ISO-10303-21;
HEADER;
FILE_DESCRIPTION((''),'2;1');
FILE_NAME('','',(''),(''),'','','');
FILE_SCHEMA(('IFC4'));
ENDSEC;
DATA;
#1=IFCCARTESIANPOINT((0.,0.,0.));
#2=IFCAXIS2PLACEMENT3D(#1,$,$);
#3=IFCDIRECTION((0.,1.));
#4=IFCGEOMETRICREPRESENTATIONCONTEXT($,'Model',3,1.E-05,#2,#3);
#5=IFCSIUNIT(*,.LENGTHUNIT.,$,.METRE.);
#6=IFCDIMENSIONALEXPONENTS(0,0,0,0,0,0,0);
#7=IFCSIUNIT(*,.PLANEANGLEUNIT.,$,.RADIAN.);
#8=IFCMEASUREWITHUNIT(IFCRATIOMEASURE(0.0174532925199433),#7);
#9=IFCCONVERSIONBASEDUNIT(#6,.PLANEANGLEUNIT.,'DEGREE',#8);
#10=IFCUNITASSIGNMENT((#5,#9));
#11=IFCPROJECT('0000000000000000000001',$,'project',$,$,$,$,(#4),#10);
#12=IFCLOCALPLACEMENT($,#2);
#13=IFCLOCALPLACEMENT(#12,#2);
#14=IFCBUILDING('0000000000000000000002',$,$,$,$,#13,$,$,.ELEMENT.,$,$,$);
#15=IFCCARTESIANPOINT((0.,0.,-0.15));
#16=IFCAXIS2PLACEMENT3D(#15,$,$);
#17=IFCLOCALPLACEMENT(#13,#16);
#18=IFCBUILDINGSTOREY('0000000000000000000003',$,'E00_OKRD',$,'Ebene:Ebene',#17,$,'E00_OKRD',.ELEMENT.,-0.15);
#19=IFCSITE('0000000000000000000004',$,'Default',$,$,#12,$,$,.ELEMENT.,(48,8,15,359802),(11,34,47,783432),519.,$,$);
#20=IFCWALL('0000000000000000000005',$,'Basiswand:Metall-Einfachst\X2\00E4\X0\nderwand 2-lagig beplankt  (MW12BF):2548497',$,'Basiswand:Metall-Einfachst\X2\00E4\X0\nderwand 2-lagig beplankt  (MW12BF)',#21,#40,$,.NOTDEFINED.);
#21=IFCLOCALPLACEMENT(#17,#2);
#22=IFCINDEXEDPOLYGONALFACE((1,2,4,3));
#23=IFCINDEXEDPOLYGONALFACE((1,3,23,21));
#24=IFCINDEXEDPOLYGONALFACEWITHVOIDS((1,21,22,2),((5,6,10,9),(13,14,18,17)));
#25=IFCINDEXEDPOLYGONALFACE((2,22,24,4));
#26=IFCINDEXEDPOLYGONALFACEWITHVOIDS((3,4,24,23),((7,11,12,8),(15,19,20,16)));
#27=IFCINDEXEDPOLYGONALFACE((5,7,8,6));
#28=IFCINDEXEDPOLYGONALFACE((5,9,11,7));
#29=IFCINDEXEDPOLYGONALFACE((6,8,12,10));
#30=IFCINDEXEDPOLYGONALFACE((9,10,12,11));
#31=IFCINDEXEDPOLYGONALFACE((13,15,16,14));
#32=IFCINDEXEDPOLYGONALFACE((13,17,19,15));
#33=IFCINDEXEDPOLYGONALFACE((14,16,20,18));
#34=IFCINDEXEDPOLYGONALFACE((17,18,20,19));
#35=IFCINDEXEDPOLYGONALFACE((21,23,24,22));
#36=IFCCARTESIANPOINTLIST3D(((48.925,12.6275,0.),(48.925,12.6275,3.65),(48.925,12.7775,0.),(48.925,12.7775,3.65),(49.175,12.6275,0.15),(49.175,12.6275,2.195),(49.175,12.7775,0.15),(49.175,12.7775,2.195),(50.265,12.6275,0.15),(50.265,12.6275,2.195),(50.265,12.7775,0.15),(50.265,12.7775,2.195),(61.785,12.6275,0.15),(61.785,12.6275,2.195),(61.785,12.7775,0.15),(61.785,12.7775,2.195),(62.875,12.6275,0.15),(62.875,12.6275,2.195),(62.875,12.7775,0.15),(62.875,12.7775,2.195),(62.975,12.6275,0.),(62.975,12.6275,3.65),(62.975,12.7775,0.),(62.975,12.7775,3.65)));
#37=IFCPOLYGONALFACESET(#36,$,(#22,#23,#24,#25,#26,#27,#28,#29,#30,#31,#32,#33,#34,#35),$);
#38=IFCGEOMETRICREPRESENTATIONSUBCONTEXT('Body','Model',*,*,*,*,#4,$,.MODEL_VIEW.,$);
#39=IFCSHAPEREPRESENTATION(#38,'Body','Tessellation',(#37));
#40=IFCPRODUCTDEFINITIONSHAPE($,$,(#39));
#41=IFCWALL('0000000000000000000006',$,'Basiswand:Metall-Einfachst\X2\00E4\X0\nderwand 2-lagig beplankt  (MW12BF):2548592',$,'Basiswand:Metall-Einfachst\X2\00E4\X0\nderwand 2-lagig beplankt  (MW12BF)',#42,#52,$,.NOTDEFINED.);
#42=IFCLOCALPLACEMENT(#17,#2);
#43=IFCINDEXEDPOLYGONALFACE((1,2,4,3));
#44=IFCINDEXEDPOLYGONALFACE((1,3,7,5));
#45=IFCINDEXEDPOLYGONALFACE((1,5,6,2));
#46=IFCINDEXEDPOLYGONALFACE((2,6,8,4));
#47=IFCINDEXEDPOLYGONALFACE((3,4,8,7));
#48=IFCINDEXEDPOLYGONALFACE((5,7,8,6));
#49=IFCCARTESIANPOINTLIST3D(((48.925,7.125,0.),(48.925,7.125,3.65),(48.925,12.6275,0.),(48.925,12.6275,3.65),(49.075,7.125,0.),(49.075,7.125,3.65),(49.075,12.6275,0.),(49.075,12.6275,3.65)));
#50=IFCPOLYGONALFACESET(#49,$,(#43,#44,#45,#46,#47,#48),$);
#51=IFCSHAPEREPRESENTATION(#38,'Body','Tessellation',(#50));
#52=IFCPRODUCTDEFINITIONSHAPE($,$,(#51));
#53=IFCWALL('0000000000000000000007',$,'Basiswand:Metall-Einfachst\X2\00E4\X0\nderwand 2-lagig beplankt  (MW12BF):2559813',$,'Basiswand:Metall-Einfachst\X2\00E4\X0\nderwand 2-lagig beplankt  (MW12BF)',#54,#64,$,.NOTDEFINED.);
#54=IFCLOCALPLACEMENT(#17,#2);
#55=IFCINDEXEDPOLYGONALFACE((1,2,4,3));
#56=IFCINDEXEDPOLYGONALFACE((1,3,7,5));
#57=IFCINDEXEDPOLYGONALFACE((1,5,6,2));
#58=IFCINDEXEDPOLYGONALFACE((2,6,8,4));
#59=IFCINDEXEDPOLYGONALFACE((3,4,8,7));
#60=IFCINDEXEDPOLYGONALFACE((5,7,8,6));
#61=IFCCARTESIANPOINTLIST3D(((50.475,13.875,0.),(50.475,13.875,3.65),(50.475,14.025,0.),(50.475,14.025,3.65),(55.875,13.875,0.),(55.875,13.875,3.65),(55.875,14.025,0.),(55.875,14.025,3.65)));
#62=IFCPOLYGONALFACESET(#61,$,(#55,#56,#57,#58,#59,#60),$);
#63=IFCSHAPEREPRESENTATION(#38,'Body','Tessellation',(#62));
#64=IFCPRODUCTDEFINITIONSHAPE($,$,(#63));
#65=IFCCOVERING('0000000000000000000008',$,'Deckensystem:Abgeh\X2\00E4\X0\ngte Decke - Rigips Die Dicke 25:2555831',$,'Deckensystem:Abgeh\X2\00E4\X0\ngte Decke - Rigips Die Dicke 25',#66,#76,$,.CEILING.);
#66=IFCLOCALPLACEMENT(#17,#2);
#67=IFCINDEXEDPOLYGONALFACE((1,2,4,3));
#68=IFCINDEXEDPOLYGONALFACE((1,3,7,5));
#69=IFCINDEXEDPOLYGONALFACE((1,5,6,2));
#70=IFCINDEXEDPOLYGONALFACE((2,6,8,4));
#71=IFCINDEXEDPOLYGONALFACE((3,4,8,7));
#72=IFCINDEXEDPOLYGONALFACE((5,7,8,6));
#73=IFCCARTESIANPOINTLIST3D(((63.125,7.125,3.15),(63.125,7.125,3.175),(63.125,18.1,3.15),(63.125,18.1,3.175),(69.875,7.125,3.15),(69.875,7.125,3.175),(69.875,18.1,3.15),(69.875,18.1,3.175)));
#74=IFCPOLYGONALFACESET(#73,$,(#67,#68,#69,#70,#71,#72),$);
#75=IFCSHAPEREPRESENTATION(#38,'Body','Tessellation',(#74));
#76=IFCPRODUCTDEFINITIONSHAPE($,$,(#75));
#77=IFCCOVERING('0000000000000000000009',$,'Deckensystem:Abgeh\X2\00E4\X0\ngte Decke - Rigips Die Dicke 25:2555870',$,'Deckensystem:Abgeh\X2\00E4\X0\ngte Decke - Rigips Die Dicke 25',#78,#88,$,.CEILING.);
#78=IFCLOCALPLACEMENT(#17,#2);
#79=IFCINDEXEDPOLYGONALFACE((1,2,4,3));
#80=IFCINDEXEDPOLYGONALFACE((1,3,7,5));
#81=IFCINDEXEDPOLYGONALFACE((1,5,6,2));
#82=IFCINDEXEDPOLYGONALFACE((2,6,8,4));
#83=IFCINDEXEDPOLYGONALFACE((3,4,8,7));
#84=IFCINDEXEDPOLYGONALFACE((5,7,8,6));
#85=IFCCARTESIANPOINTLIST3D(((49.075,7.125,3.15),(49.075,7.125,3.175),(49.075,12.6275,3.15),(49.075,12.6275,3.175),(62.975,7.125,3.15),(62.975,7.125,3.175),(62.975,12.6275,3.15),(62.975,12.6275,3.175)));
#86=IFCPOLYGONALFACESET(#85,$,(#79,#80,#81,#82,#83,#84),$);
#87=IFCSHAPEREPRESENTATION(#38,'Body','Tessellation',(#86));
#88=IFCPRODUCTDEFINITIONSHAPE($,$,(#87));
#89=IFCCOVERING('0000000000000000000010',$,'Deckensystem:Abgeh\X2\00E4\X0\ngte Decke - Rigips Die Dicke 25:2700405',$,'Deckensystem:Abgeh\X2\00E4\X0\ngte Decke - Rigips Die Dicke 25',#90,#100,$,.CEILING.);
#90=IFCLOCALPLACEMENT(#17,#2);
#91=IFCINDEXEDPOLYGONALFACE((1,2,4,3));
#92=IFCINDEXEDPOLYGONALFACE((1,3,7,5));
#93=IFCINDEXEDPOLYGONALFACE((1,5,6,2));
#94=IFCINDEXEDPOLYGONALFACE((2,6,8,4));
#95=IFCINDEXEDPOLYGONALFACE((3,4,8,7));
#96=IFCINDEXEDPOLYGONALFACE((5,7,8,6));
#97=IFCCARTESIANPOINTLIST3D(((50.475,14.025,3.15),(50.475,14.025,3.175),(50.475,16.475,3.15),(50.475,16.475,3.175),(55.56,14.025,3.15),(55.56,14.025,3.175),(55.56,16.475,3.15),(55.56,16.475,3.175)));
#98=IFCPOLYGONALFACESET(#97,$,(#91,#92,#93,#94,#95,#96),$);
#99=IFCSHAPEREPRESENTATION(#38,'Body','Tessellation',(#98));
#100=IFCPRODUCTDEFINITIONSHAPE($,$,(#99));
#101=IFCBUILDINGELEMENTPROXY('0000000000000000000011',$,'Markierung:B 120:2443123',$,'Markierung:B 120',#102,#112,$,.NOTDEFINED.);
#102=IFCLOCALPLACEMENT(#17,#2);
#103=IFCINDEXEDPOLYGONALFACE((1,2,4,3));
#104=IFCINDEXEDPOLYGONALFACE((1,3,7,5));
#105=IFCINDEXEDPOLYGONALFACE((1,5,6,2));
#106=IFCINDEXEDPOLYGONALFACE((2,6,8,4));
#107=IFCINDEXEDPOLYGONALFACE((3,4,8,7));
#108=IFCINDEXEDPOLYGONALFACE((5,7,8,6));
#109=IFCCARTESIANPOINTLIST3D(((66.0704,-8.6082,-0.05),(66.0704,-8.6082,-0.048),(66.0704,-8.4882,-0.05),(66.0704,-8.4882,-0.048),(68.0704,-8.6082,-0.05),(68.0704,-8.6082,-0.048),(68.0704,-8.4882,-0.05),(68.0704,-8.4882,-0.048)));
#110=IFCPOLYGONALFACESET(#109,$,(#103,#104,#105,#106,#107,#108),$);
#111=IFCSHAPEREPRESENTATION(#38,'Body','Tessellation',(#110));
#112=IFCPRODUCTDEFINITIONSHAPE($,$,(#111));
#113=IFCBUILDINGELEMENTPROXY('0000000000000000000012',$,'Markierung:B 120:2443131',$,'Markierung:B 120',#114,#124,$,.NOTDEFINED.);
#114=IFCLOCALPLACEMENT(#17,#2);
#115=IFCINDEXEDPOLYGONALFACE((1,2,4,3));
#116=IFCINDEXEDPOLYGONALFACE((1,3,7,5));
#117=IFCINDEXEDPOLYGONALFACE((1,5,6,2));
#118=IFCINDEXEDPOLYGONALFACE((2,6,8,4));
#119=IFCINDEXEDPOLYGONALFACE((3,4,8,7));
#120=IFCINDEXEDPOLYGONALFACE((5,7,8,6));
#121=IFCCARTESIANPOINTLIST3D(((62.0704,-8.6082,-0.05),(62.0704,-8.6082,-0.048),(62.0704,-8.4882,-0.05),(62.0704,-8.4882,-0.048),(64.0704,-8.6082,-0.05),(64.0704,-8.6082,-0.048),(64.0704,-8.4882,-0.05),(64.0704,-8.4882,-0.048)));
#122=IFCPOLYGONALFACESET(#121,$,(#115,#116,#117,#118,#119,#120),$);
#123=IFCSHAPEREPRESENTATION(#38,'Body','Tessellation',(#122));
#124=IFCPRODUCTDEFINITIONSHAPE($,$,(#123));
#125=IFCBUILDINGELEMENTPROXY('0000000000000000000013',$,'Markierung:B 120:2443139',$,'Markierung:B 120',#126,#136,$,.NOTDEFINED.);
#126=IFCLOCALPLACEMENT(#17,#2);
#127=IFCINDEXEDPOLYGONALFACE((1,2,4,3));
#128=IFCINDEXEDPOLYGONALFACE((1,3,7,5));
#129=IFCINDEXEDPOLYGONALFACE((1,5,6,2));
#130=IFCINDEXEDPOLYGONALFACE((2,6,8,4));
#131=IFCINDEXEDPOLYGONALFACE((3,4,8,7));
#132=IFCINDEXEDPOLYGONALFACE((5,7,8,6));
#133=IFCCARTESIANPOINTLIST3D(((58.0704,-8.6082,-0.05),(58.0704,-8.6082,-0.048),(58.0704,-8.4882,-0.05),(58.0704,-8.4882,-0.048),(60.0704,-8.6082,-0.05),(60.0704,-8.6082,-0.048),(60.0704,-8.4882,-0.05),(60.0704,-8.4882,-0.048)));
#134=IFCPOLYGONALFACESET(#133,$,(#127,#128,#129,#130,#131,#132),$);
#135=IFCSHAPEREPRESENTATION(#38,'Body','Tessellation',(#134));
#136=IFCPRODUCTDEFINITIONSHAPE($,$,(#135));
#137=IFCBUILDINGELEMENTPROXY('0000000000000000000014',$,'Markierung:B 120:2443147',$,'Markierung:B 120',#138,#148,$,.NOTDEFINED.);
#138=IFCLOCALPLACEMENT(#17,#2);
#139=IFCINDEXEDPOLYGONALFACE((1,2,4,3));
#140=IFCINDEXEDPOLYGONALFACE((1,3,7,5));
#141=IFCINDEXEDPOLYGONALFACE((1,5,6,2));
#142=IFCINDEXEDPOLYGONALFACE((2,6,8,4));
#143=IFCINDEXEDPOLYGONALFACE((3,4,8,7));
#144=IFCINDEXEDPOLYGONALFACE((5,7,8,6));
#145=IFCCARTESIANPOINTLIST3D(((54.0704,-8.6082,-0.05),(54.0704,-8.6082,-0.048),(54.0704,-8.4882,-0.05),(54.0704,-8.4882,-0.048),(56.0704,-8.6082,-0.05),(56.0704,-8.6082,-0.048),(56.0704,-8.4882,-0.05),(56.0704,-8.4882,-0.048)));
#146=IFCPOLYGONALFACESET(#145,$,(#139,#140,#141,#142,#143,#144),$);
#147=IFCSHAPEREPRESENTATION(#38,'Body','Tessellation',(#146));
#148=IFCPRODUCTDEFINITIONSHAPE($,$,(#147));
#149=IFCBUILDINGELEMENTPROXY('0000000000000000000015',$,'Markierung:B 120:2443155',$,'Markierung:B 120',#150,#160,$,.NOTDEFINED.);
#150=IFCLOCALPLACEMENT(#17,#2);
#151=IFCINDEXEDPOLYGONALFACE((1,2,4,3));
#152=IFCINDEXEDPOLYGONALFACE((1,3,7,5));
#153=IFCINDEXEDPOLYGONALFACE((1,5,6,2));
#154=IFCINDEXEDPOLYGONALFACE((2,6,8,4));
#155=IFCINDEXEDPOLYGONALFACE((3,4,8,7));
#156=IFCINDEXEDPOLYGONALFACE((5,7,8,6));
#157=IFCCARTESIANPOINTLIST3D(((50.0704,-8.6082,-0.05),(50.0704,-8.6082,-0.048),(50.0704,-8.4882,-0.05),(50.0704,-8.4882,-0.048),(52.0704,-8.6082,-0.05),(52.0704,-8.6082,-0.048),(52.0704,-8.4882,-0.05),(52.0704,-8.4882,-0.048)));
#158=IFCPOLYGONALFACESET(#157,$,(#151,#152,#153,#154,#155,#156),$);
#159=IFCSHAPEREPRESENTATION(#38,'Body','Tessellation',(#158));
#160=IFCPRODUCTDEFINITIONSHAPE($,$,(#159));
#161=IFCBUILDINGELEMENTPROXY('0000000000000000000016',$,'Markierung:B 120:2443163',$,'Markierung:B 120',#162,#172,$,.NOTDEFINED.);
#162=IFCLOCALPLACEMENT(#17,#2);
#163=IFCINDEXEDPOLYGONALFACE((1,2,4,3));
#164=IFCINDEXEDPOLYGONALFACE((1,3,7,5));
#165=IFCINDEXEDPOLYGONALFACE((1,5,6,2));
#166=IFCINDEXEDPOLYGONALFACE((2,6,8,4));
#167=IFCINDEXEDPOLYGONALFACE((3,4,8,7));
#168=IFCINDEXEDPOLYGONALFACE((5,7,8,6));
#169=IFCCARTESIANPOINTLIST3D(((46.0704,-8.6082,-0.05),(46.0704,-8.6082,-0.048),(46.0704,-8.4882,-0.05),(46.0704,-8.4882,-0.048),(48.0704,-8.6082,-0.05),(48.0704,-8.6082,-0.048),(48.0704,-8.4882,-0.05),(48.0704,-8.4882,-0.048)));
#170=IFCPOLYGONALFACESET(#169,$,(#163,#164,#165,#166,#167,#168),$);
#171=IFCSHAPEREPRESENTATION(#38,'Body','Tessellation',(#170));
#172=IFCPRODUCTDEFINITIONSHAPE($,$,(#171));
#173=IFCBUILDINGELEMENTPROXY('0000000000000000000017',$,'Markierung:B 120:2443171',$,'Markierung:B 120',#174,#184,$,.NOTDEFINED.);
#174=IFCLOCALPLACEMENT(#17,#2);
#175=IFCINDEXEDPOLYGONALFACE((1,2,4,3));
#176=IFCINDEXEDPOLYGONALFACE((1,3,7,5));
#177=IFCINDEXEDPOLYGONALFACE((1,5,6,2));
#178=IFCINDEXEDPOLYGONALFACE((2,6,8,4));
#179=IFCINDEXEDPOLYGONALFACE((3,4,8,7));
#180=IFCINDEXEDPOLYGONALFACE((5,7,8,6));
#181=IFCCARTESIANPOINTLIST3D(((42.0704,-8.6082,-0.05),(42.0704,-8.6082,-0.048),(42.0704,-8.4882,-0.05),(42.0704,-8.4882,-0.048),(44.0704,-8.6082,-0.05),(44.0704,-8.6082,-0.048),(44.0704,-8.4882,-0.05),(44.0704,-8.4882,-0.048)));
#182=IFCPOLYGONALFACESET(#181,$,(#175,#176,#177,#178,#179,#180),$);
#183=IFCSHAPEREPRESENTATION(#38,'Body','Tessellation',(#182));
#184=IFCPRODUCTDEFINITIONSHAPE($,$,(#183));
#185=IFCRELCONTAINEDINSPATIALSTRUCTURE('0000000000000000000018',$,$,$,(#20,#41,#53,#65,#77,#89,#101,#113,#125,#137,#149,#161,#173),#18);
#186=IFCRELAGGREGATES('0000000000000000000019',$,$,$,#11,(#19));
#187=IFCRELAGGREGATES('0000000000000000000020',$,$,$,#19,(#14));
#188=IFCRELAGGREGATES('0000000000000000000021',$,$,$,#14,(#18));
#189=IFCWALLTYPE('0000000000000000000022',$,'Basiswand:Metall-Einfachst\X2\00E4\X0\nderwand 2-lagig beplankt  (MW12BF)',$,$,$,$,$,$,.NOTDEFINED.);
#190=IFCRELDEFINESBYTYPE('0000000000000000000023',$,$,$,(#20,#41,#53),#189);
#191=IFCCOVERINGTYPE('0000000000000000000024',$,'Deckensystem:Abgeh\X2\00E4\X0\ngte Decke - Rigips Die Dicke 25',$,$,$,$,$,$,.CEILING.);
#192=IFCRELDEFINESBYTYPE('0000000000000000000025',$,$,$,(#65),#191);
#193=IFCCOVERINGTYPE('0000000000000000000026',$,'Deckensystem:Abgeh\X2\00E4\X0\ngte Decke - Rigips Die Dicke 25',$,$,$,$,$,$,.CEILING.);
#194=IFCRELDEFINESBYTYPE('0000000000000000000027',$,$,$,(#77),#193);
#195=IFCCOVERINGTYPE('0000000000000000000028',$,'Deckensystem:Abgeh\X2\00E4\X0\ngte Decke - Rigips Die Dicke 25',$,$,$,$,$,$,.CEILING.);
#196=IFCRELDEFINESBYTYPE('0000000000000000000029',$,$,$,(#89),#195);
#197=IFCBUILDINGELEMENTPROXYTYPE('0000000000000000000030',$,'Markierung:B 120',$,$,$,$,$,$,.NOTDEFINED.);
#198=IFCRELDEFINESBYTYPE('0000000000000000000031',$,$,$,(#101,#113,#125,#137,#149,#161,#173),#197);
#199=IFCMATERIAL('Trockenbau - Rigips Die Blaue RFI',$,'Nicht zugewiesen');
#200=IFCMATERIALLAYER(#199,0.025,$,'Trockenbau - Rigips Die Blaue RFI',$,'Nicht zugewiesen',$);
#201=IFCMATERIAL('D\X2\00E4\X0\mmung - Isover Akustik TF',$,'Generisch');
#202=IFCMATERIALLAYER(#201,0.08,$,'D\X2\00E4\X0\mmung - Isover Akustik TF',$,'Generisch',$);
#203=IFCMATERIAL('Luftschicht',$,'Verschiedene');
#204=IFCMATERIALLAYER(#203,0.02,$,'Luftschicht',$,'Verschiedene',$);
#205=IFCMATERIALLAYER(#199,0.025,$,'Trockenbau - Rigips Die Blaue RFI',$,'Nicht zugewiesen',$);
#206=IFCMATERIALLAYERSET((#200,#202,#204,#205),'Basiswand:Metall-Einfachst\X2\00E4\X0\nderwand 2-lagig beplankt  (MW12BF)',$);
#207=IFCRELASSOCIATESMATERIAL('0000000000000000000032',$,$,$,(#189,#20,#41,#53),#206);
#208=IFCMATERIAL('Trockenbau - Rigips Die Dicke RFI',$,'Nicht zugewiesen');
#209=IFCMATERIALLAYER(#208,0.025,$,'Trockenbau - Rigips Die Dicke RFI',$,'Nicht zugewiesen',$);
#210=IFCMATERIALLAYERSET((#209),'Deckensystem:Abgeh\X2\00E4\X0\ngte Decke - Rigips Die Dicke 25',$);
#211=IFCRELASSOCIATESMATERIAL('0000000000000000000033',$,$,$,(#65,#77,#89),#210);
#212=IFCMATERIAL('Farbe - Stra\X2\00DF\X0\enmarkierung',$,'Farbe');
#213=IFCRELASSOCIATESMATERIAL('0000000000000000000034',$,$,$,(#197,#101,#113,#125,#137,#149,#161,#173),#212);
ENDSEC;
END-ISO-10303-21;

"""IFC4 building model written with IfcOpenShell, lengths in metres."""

from ifc_helpers import new_model, entity, si_unit, converted_unit, direction, frame, frame_2d, origin, place, context, subcontext, project, spatial, rectangle, extrude, source, transform, mapped, material, layer, layer_set, layer_usage, type_object, type_shapes, element, save


model = new_model("IFC4")

# Units and contexts
model_context = context("Model", 3, precision=1e-05, world=origin(), true_north=direction((0.0, 1.0)))
body_context = subcontext(model_context, "Body", "Model", "MODEL_VIEW")
ifc_project = project(units=[si_unit("LENGTHUNIT", "METRE"), converted_unit("PLANEANGLEUNIT", "DEGREE", entity("IfcRatioMeasure", 0.0174532925199433), si_unit("PLANEANGLEUNIT", "RADIAN"), dimensions=[0, 0, 0, 0, 0, 0, 0])], contexts=[model_context])

# Site, building, storey
site_placement = place(None, frame((0.0, 0.0, 0.0)))
site = spatial("IfcSite", under=ifc_project, at=site_placement, Name="Default", CompositionType="ELEMENT", RefLatitude=(48, 8, 15, 359802), RefLongitude=(11, 34, 47, 783432), RefElevation=519.0)
building_placement = place(site_placement, origin())
building = spatial("IfcBuilding", under=site, at=building_placement, CompositionType="ELEMENT")
storey_placement = place(building_placement, frame((0.0, 0.0, -0.15)))
storey = spatial("IfcBuildingStorey", under=building, at=storey_placement, Name="E00_OKRD", ObjectType="Ebene:Ebene", LongName="E00_OKRD", CompositionType="ELEMENT", Elevation=-0.15)

# Shared definitions
ifc_material_1 = material(Name="Trockenbau - Rigips Die Blaue RFI", Category="Nicht zugewiesen")
ifc_layer_1 = layer(ifc_material_1, 0.025, Name="Trockenbau - Rigips Die Blaue RFI", Category="Nicht zugewiesen")
ifc_material_2 = material(Name="Dämmung - Isover Akustik TF", Category="Generisch")
ifc_layer_2 = layer(ifc_material_2, 0.08, Name="Dämmung - Isover Akustik TF", Category="Generisch")
ifc_material_3 = material(Name="Luftschicht", Category="Verschiedene")
ifc_layer_3 = layer(ifc_material_3, 0.02, Name="Luftschicht", Category="Verschiedene")
ifc_layer_4 = layer(ifc_material_1, 0.025, Name="Trockenbau - Rigips Die Blaue RFI", Category="Nicht zugewiesen")
ifc_layer_set_1 = layer_set([ifc_layer_1, ifc_layer_2, ifc_layer_3, ifc_layer_4], Name="Basiswand:Metall-Einfachständerwand 2-lagig beplankt  (MW12BF)")
wall_type_1 = type_object("IfcWallType", Name="Basiswand:Metall-Einfachständerwand 2-lagig beplankt  (MW12BF)", PredefinedType="NOTDEFINED", material=ifc_layer_set_1)

# Wall, openings
ifc_layer_usage_1 = layer_usage(ifc_layer_set_1, "AXIS2", "NEGATIVE", 0.075)
wall_1_placement = place(storey_placement, frame((62.975, 12.7025, 0.0), z_axis=(0.0, 0.0, 1.0), x_axis=(-1.0, 0.0, 0.0)))
wall_1 = element("IfcWall", 1, at=wall_1_placement, inside=storey, type_object=wall_type_1, material=ifc_layer_usage_1, Name="Basiswand:Metall-Einfachständerwand 2-lagig beplankt  (MW12BF):2548497", ObjectType="Basiswand:Metall-Einfachständerwand 2-lagig beplankt  (MW12BF)", PredefinedType="NOTDEFINED", context=body_context, shape_type="SweptSolid", body=[
    extrude(rectangle(XDim=14.05, YDim=0.15, at=frame_2d((7.025, 0.0), x_axis=(-1.0, 0.0))), origin(), (0.0, 0.0, 1.0), 3.65),
])
opening_1_placement = place(wall_1_placement, frame((12.71, -0.075, 0.15)))
element("IfcOpeningElement", 2, at=opening_1_placement, cuts=wall_1, ObjectType="Opening", PredefinedType="OPENING", context=body_context, shape_type="SweptSolid", body=[
    extrude(rectangle(XDim=2.045, YDim=1.09, at=frame_2d((1.0225, 0.545), x_axis=(-1.0, 0.0))), frame((0.0, 0.0, 0.0), z_axis=(0.0, 1.0, 0.0), x_axis=(0.0, 0.0, 1.0)), (0.0, 0.0, 1.0), 0.15),
])
opening_2_placement = place(wall_1_placement, frame((0.1, -0.075, 0.15)))
element("IfcOpeningElement", 3, at=opening_2_placement, cuts=wall_1, ObjectType="Opening", PredefinedType="OPENING", context=body_context, shape_type="SweptSolid", body=[
    extrude(rectangle(XDim=2.045, YDim=1.09, at=frame_2d((1.0225, 0.545), x_axis=(-1.0, 0.0))), frame((0.0, 0.0, 0.0), z_axis=(0.0, 1.0, 0.0), x_axis=(0.0, 0.0, 1.0)), (0.0, 0.0, 1.0), 0.15),
])

# Walls
ifc_layer_usage_2 = layer_usage(ifc_layer_set_1, "AXIS2", "NEGATIVE", 0.075)
wall_2_placement = place(storey_placement, frame((49.0, 12.6275, 0.0), z_axis=(0.0, 0.0, 1.0), x_axis=(0.0, -1.0, 0.0)))
element("IfcWall", 4, at=wall_2_placement, inside=storey, type_object=wall_type_1, material=ifc_layer_usage_2, Name="Basiswand:Metall-Einfachständerwand 2-lagig beplankt  (MW12BF):2548592", ObjectType="Basiswand:Metall-Einfachständerwand 2-lagig beplankt  (MW12BF)", PredefinedType="NOTDEFINED", context=body_context, shape_type="SweptSolid", body=[
    extrude(rectangle(XDim=5.5025, YDim=0.15, at=frame_2d((2.7512, 0.0), x_axis=(-1.0, 0.0))), origin(), (0.0, 0.0, 1.0), 3.65),
])
ifc_layer_usage_3 = layer_usage(ifc_layer_set_1, "AXIS2", "NEGATIVE", 0.075)
wall_3_placement = place(storey_placement, frame((55.875, 13.95, 0.0), z_axis=(0.0, 0.0, 1.0), x_axis=(-1.0, 0.0, 0.0)))
element("IfcWall", 5, at=wall_3_placement, inside=storey, type_object=wall_type_1, material=ifc_layer_usage_3, Name="Basiswand:Metall-Einfachständerwand 2-lagig beplankt  (MW12BF):2559813", ObjectType="Basiswand:Metall-Einfachständerwand 2-lagig beplankt  (MW12BF)", PredefinedType="NOTDEFINED", context=body_context, shape_type="SweptSolid", body=[
    extrude(rectangle(XDim=5.4, YDim=0.15, at=frame_2d((2.7, 0.0), x_axis=(-1.0, 0.0))), origin(), (0.0, 0.0, 1.0), 3.65),
])

# Coverings
ifc_material_4 = material(Name="Trockenbau - Rigips Die Dicke RFI", Category="Nicht zugewiesen")
ifc_layer_5 = layer(ifc_material_4, 0.025, Name="Trockenbau - Rigips Die Dicke RFI", Category="Nicht zugewiesen")
ifc_layer_set_2 = layer_set([ifc_layer_5], Name="Deckensystem:Abgehängte Decke - Rigips Die Dicke 25")
ifc_layer_usage_4 = layer_usage(ifc_layer_set_2, "AXIS3", "POSITIVE", 0.0)
covering_type_1 = type_object("IfcCoveringType", Name="Deckensystem:Abgehängte Decke - Rigips Die Dicke 25", PredefinedType="CEILING")
covering_1_placement = place(storey_placement, frame((63.125, 7.125, 3.15)))
element("IfcCovering", 6, at=covering_1_placement, inside=storey, type_object=covering_type_1, material=ifc_layer_usage_4, Name="Deckensystem:Abgehängte Decke - Rigips Die Dicke 25:2555831", ObjectType="Deckensystem:Abgehängte Decke - Rigips Die Dicke 25", PredefinedType="CEILING", context=body_context, shape_type="SweptSolid", body=[
    extrude(rectangle(XDim=6.75, YDim=10.975, at=frame_2d((0.0, 0.0), x_axis=(1.0, 0.0))), frame((3.375, 5.4875, 0.0), z_axis=(0.0, 0.0, 1.0), x_axis=(-1.0, 0.0, 0.0)), (0.0, 0.0, 1.0), 0.025),
])
ifc_layer_usage_5 = layer_usage(ifc_layer_set_2, "AXIS3", "POSITIVE", 0.0)
covering_type_2 = type_object("IfcCoveringType", Name="Deckensystem:Abgehängte Decke - Rigips Die Dicke 25", PredefinedType="CEILING")
covering_2_placement = place(storey_placement, frame((49.075, 7.125, 3.15)))
element("IfcCovering", 7, at=covering_2_placement, inside=storey, type_object=covering_type_2, material=ifc_layer_usage_5, Name="Deckensystem:Abgehängte Decke - Rigips Die Dicke 25:2555870", ObjectType="Deckensystem:Abgehängte Decke - Rigips Die Dicke 25", PredefinedType="CEILING", context=body_context, shape_type="SweptSolid", body=[
    extrude(rectangle(XDim=13.9, YDim=5.5025, at=frame_2d((0.0, 0.0), x_axis=(1.0, 0.0))), frame((6.95, 2.7512, 0.0), z_axis=(0.0, 0.0, 1.0), x_axis=(-1.0, 0.0, 0.0)), (0.0, 0.0, 1.0), 0.025),
])
ifc_layer_usage_6 = layer_usage(ifc_layer_set_2, "AXIS3", "POSITIVE", 0.0)
covering_type_3 = type_object("IfcCoveringType", Name="Deckensystem:Abgehängte Decke - Rigips Die Dicke 25", PredefinedType="CEILING")
covering_3_placement = place(storey_placement, frame((50.475, 14.025, 3.15)))
element("IfcCovering", 8, at=covering_3_placement, inside=storey, type_object=covering_type_3, material=ifc_layer_usage_6, Name="Deckensystem:Abgehängte Decke - Rigips Die Dicke 25:2700405", ObjectType="Deckensystem:Abgehängte Decke - Rigips Die Dicke 25", PredefinedType="CEILING", context=body_context, shape_type="SweptSolid", body=[
    extrude(rectangle(XDim=5.085, YDim=2.45, at=frame_2d((0.0, 0.0), x_axis=(1.0, 0.0))), frame((2.5425, 1.225, 0.0), z_axis=(0.0, 0.0, 1.0), x_axis=(-1.0, 0.0, 0.0)), (0.0, 0.0, 1.0), 0.025),
])

# Building element proxies
ifc_material_5 = material(Name="Farbe - Straßenmarkierung", Category="Farbe")
building_element_proxy_type_1 = type_object("IfcBuildingElementProxyType", Name="Markierung:B 120", PredefinedType="NOTDEFINED", material=ifc_material_5)
shared_shape_1 = source(origin(), body_context, "Body", "SweptSolid", [
    extrude(rectangle(XDim=0.12, YDim=2.0, at=frame_2d((0.0, 0.0), x_axis=(1.0, 0.0))), frame((0.06, 1.0, 0.0), z_axis=(0.0, 0.0, 1.0), x_axis=(-1.0, 0.0, 0.0)), (0.0, 0.0, 1.0), 0.002),
])
type_shapes(building_element_proxy_type_1, [shared_shape_1])
for number, where, z_axis, x_axis, name in (
    (9, (68.0704, -8.6082, -0.05), (0.0, 0.0, 1.0), (0.0, 1.0, 0.0), "Markierung:B 120:2443123"),
    (10, (64.0704, -8.6082, -0.05), (0.0, 0.0, 1.0), (0.0, 1.0, 0.0), "Markierung:B 120:2443131"),
    (11, (60.0704, -8.6082, -0.05), (0.0, 0.0, 1.0), (0.0, 1.0, 0.0), "Markierung:B 120:2443139"),
    (12, (56.0704, -8.6082, -0.05), (0.0, 0.0, 1.0), (0.0, 1.0, 0.0), "Markierung:B 120:2443147"),
    (13, (52.0704, -8.6082, -0.05), (0.0, 0.0, 1.0), (0.0, 1.0, 0.0), "Markierung:B 120:2443155"),
    (14, (48.0704, -8.6082, -0.05), (0.0, 0.0, 1.0), (0.0, 1.0, 0.0), "Markierung:B 120:2443163"),
    (15, (44.0704, -8.6082, -0.05), (0.0, 0.0, 1.0), (0.0, 1.0, 0.0), "Markierung:B 120:2443171"),
):
    element("IfcBuildingElementProxy", number, at=place(storey_placement, frame(where, z_axis=z_axis, x_axis=x_axis)), inside=storey, type_object=building_element_proxy_type_1, material=ifc_material_5, Name=name, ObjectType="Markierung:B 120", PredefinedType="NOTDEFINED", context=body_context, shape_type="MappedRepresentation", body=[
        mapped(shared_shape_1, transform((0.0, 0.0, 0.0), scale=1.0)),
    ])

save(model, "model.ifc")
